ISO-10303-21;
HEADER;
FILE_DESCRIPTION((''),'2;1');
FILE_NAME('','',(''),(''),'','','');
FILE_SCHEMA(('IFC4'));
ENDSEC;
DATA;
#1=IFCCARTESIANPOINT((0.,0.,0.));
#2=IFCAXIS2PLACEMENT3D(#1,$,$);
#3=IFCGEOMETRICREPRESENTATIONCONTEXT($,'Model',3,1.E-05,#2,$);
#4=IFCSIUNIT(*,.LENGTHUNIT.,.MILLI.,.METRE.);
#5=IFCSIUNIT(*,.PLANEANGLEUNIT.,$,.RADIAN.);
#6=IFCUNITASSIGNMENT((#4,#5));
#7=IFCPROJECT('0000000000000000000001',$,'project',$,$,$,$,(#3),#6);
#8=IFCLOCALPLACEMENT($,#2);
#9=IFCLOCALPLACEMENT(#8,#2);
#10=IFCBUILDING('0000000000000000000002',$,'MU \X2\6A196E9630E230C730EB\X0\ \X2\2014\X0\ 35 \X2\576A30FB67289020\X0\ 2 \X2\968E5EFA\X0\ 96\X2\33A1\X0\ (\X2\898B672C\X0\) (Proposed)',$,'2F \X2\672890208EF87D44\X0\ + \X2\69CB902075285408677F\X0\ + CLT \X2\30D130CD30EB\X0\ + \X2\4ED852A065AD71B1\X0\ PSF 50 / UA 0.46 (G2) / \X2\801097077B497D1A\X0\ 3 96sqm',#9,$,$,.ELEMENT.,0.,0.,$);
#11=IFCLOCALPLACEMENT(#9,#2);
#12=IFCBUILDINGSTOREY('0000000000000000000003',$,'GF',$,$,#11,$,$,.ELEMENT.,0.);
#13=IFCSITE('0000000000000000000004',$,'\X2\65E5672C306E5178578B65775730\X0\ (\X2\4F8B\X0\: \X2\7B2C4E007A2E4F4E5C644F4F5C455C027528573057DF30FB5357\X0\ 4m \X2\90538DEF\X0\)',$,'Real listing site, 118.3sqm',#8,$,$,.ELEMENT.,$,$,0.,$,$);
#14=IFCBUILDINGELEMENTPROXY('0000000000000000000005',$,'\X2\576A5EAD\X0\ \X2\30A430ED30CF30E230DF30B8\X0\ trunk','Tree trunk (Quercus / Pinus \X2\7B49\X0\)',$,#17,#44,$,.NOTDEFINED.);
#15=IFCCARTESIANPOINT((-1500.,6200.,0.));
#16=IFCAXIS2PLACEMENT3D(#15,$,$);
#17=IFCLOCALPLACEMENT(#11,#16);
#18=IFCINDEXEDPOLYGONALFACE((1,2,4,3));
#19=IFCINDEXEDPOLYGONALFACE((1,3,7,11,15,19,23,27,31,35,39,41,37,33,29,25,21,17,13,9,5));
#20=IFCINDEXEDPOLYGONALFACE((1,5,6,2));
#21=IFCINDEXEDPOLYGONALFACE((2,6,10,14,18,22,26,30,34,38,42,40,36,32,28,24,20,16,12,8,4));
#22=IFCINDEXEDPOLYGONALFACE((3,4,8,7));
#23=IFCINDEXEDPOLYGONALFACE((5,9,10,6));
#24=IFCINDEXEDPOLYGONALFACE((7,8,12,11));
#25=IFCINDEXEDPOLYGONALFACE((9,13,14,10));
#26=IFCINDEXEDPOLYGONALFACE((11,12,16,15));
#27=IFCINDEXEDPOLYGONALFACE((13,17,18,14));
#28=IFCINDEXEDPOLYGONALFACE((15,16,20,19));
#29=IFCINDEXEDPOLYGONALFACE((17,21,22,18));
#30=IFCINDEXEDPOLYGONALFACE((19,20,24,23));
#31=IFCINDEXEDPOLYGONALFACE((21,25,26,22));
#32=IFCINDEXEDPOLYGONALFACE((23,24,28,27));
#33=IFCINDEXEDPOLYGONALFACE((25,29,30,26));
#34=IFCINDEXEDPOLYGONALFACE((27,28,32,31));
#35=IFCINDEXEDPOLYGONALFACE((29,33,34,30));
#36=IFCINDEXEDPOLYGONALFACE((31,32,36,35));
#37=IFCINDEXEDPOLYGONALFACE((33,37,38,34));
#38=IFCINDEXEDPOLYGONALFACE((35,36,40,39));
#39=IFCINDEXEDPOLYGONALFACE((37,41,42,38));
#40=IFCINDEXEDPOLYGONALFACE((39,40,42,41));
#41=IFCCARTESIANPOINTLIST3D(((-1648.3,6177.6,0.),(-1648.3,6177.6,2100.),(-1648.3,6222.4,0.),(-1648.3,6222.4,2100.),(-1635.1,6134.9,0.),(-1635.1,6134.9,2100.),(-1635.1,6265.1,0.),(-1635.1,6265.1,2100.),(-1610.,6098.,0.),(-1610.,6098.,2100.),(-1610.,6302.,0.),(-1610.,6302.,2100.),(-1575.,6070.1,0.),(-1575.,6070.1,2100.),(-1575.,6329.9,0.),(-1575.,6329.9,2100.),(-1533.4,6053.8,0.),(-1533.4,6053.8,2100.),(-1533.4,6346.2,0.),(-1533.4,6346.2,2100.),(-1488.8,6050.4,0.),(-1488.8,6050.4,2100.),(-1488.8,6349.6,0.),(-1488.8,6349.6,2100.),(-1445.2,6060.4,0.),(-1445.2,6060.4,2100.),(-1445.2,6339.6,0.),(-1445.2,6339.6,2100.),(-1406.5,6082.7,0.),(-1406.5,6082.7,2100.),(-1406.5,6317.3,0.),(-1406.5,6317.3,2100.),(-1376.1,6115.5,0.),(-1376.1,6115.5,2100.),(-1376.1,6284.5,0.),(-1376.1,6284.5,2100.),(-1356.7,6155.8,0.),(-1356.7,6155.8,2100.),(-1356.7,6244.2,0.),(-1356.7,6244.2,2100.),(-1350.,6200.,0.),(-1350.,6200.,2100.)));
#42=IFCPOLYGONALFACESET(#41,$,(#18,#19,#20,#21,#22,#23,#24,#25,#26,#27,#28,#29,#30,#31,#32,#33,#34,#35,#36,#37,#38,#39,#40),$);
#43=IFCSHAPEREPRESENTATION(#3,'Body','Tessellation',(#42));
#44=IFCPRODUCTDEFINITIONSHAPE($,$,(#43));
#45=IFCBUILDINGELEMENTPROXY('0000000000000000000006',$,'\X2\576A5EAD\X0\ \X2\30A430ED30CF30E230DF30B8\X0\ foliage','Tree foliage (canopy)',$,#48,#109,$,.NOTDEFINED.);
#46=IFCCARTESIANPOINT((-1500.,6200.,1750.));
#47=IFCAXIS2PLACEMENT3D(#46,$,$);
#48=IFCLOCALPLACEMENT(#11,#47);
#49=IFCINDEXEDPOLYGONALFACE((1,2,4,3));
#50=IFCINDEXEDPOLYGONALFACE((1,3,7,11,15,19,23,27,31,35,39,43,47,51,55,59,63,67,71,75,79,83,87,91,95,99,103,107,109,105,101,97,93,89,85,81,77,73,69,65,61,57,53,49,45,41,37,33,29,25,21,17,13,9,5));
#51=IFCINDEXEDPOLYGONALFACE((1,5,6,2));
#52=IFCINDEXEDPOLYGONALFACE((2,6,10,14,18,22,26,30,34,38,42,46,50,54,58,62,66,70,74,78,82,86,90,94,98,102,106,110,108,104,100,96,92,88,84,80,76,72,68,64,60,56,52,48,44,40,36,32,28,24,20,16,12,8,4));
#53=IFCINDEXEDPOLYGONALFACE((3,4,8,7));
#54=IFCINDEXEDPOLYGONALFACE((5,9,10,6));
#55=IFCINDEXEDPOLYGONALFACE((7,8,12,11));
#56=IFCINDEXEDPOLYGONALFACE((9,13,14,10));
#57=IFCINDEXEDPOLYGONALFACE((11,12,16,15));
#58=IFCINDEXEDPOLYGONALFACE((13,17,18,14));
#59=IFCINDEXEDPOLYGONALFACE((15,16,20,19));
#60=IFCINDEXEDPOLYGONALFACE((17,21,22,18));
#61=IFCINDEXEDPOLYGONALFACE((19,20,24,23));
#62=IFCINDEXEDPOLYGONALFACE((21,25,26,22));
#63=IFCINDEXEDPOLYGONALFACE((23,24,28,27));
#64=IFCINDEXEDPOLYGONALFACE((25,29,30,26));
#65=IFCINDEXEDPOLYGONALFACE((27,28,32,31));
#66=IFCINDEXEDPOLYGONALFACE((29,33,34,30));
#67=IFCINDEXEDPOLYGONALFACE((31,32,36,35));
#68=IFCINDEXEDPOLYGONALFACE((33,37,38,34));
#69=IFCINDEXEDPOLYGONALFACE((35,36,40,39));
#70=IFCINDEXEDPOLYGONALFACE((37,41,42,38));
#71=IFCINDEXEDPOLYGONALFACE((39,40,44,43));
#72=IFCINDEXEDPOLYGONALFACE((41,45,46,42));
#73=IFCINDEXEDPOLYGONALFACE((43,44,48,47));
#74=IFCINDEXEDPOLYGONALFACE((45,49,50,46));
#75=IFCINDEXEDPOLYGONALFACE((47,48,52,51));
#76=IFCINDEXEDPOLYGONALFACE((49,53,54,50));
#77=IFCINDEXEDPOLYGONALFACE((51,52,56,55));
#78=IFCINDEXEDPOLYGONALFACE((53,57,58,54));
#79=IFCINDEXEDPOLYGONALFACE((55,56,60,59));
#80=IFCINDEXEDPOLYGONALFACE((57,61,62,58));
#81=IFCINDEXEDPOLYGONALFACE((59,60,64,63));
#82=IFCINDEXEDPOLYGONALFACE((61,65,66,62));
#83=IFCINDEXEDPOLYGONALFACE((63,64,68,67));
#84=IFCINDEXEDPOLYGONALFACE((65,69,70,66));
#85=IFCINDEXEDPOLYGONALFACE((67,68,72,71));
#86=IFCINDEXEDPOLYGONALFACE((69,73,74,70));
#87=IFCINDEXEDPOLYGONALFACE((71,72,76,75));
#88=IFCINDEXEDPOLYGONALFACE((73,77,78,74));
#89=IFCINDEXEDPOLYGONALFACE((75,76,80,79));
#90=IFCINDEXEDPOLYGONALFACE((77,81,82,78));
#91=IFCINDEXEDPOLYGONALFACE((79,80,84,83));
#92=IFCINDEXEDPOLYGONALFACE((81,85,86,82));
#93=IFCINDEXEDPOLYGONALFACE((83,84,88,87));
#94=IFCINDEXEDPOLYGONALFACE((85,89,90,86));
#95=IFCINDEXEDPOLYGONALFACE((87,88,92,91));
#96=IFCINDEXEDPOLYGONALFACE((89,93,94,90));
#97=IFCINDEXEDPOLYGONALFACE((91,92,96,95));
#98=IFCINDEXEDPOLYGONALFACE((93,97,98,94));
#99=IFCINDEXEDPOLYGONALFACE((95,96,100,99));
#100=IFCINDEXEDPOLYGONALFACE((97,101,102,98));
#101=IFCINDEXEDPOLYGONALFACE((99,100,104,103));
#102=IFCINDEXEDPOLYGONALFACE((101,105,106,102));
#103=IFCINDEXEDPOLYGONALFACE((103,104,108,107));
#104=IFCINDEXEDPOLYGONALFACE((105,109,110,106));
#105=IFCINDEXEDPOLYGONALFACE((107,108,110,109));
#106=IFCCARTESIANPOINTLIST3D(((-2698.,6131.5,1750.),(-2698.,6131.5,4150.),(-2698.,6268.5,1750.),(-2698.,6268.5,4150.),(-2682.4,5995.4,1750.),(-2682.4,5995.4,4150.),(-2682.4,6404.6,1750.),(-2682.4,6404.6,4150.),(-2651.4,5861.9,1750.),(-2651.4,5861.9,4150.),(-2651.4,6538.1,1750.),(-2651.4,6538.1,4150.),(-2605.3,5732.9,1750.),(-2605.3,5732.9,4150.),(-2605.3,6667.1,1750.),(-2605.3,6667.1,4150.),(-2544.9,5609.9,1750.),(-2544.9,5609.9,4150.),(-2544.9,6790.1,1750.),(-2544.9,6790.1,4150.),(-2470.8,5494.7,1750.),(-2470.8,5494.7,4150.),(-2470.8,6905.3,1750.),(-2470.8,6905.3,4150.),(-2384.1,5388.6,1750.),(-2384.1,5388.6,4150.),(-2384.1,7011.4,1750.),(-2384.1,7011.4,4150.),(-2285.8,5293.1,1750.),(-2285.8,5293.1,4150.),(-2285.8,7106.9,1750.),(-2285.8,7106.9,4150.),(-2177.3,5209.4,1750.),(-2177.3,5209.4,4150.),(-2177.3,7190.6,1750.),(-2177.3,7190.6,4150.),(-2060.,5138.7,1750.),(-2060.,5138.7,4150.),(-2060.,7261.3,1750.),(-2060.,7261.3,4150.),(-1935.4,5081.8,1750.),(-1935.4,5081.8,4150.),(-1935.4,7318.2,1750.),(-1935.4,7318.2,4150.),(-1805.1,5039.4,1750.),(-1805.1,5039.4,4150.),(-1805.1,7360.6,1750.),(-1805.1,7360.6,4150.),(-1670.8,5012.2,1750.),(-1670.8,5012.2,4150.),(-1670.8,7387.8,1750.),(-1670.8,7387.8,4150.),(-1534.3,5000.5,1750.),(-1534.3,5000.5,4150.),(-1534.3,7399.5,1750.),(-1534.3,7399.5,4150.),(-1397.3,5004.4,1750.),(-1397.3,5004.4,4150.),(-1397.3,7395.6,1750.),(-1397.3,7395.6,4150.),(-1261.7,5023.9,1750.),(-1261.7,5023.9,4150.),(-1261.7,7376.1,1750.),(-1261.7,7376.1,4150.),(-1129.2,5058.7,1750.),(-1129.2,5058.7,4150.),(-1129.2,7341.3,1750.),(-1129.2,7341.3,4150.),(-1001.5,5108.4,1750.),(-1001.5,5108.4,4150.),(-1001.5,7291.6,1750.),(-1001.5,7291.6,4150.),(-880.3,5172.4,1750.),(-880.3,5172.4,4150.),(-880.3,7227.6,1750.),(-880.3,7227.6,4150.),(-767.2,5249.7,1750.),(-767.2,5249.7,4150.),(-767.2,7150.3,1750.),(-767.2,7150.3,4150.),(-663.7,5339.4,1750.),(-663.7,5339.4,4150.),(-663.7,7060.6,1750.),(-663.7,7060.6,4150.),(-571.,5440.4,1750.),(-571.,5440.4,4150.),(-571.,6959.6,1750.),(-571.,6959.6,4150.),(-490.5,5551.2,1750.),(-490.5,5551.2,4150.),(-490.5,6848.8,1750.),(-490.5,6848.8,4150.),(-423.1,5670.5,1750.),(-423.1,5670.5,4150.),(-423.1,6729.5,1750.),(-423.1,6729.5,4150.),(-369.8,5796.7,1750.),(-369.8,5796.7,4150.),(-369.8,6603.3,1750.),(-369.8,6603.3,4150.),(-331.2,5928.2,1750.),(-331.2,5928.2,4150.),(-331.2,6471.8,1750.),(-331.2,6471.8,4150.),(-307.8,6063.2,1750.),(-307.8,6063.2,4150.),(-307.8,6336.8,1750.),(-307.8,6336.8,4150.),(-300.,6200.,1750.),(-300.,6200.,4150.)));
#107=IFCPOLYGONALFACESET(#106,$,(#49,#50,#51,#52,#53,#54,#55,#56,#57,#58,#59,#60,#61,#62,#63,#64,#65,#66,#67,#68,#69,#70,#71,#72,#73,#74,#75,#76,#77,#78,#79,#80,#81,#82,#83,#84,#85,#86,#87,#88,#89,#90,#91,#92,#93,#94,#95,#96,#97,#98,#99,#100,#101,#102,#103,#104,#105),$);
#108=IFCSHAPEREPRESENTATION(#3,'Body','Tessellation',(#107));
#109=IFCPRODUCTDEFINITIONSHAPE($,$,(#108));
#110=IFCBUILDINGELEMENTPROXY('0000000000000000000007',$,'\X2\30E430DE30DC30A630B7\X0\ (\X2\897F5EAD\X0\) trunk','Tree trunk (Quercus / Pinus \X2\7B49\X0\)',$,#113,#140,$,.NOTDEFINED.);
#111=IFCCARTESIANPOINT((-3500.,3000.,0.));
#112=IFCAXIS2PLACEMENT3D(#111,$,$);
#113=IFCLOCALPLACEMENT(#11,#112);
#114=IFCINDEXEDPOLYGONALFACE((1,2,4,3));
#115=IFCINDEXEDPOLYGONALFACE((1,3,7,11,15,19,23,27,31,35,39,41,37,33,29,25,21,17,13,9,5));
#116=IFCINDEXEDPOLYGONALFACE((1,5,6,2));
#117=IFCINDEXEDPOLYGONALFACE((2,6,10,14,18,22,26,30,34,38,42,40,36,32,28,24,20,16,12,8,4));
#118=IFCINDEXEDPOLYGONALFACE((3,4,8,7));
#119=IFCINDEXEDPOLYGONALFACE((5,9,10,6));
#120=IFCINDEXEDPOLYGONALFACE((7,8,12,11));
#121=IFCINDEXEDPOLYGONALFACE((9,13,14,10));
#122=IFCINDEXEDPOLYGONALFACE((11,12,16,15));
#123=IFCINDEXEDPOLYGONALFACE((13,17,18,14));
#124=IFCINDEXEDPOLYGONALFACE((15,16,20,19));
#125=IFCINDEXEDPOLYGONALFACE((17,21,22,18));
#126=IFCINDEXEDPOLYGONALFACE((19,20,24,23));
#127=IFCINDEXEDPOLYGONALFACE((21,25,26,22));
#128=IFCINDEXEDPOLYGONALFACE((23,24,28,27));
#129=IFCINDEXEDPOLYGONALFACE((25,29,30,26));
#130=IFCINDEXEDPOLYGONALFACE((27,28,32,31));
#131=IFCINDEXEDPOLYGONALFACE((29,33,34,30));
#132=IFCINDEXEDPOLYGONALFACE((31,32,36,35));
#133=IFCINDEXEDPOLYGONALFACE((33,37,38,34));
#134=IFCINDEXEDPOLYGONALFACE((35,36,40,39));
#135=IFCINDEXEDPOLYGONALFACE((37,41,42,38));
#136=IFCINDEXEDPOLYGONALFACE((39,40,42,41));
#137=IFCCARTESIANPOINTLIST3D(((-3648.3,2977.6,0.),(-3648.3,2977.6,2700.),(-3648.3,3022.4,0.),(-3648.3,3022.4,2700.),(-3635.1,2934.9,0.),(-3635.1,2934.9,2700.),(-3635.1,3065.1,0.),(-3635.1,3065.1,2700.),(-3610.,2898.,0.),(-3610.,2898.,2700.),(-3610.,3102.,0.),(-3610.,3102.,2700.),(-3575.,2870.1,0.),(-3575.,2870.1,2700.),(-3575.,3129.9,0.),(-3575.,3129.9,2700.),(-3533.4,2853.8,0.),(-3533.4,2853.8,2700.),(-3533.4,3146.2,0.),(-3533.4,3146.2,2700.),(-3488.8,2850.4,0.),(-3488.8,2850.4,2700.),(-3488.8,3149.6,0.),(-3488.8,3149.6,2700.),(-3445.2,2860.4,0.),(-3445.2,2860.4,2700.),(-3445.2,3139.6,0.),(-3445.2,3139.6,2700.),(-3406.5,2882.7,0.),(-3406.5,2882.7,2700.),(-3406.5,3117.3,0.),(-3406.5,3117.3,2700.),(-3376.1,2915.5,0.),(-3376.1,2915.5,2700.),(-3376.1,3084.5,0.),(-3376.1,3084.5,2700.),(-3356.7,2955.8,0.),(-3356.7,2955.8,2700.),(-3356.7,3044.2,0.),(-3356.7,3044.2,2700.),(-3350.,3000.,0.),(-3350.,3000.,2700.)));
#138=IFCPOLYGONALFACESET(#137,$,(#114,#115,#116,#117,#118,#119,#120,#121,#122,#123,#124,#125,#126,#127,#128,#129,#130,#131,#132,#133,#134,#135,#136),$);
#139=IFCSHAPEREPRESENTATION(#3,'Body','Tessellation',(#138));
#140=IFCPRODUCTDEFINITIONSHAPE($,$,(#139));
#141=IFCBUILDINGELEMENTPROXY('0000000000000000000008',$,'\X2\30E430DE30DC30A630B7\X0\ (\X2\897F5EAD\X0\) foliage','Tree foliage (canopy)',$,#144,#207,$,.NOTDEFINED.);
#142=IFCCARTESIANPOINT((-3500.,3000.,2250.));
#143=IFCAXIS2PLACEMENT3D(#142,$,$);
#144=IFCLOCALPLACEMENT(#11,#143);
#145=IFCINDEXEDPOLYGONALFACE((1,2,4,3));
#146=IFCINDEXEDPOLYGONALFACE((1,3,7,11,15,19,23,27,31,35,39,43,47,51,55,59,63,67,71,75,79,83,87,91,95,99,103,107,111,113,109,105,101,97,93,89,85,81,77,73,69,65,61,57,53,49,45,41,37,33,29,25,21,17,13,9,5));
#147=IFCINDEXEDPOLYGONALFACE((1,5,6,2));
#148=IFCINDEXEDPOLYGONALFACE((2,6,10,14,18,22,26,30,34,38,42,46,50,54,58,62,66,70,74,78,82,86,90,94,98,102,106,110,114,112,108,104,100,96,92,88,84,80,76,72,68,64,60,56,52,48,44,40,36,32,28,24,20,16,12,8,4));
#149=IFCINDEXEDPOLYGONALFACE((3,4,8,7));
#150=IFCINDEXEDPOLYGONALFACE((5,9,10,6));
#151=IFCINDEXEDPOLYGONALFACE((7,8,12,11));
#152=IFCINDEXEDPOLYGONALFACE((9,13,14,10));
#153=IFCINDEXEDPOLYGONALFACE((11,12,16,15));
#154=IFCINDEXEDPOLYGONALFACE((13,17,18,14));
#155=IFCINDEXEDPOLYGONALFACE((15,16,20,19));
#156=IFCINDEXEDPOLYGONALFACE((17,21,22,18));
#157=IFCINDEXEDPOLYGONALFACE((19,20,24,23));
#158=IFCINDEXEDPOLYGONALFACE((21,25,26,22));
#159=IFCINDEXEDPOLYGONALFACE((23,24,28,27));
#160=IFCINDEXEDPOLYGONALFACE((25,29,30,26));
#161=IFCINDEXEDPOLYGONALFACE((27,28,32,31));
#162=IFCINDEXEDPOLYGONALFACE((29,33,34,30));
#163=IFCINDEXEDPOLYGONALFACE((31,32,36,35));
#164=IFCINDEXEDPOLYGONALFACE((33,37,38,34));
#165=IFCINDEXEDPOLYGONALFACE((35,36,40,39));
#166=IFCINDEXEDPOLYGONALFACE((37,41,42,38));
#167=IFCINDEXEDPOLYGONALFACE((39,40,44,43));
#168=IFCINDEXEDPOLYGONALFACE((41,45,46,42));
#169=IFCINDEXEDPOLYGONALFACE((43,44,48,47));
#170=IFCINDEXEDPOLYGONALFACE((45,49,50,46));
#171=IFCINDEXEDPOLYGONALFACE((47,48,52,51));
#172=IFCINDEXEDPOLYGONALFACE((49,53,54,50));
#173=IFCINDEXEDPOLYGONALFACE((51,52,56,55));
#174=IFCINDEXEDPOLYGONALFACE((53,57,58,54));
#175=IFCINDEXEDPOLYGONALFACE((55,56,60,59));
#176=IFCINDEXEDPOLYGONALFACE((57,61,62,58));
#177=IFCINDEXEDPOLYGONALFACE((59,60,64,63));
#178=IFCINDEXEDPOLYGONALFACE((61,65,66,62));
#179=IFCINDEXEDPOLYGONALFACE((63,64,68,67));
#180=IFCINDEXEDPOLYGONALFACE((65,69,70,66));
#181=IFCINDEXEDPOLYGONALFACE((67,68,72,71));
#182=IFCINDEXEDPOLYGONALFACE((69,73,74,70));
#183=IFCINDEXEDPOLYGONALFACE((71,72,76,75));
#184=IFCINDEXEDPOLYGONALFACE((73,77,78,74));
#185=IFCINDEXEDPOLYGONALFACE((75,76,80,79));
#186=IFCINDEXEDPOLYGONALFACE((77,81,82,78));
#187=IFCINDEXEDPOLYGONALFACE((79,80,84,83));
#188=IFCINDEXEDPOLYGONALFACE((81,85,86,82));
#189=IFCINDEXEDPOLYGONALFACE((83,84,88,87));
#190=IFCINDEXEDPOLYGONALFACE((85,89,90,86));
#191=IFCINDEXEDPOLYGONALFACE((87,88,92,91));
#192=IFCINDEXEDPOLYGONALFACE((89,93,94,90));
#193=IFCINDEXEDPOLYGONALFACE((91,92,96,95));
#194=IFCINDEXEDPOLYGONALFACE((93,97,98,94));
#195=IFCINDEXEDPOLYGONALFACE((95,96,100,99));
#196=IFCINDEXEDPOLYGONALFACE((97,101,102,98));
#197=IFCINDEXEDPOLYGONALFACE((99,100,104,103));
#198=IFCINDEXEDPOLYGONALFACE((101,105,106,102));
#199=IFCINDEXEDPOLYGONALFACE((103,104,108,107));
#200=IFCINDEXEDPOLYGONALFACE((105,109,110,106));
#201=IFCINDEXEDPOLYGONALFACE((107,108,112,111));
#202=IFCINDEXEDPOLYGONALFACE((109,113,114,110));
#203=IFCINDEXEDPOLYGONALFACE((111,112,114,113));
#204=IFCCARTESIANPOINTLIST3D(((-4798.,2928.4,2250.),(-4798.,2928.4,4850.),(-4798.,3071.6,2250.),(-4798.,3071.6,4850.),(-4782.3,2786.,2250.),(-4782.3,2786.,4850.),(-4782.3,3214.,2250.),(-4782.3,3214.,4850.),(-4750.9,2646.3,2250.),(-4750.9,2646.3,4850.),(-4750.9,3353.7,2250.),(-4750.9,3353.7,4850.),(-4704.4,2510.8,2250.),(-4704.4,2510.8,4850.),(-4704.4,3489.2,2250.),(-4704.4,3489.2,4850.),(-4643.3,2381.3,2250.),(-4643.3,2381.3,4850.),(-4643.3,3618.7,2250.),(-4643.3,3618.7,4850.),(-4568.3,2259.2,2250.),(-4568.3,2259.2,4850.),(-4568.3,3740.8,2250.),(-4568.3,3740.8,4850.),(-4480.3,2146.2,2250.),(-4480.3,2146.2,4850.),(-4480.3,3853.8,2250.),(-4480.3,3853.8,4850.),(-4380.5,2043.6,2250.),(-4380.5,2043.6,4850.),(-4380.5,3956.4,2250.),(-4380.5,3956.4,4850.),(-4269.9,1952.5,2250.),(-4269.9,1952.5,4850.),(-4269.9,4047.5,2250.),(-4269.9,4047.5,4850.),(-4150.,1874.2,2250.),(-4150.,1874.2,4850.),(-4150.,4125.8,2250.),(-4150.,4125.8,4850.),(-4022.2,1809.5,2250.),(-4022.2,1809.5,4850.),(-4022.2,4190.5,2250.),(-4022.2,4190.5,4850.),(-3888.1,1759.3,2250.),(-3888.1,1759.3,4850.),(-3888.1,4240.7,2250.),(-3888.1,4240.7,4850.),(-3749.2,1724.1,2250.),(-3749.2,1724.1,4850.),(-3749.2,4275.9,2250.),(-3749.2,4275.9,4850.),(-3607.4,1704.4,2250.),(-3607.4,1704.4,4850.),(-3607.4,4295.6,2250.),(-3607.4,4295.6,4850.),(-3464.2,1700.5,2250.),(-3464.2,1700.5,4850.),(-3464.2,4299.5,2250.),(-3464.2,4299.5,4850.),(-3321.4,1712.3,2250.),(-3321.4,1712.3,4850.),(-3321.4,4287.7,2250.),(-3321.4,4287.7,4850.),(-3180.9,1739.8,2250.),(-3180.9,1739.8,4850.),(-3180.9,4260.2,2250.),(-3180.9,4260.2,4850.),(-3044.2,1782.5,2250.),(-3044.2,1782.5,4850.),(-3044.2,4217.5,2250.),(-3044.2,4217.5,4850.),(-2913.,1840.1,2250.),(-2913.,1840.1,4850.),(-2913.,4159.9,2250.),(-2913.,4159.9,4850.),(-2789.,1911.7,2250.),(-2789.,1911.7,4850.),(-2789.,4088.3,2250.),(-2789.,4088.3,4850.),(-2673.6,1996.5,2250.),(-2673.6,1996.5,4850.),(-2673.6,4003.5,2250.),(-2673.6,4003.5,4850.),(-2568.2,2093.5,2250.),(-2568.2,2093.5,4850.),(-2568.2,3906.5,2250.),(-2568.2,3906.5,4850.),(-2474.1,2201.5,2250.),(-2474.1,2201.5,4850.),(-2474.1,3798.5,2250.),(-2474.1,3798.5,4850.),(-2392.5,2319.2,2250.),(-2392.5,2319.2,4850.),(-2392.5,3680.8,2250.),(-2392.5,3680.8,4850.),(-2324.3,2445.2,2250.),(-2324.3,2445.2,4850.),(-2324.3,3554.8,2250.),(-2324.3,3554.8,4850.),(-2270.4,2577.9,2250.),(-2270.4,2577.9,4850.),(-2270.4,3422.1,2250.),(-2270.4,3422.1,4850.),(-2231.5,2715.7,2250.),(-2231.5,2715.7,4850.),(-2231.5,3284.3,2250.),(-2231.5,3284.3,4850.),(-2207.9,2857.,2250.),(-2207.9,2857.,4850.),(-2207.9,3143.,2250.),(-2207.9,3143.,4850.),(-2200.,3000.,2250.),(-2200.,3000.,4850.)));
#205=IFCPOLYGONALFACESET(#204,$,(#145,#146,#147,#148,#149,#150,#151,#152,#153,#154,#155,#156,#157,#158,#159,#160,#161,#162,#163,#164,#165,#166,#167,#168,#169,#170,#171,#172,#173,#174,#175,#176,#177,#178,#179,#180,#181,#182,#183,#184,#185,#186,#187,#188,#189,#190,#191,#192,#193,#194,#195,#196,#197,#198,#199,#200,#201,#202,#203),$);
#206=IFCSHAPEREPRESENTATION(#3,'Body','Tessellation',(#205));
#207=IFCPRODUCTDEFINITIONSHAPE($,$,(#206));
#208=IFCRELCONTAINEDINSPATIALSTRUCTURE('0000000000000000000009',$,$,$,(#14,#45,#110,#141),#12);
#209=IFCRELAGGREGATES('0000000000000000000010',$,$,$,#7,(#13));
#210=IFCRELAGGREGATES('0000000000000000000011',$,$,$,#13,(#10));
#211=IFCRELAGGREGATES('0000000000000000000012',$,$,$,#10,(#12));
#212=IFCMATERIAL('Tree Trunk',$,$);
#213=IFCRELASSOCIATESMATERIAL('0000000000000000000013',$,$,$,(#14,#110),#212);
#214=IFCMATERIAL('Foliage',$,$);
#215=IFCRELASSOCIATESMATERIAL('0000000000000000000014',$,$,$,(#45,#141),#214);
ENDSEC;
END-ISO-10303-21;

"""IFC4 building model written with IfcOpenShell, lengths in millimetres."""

from ifc_helpers import new_model, si_unit, frame, origin, origin_2d, place, context, project, spatial, circle, extrude, material, element, save


model = new_model("IFC4")

# Units and contexts
model_context = context("Model", 3, precision=1e-05, world=origin())
ifc_project = project(units=[si_unit("LENGTHUNIT", "METRE", prefix="MILLI"), si_unit("PLANEANGLEUNIT", "RADIAN")], contexts=[model_context])

# Site, building, storey
site_placement = place(None, origin())
site = spatial("IfcSite", under=ifc_project, at=site_placement, Name="日本の典型敷地 (例: 第一種低層住居専用地域・南 4m 道路)", ObjectType="Real listing site, 118.3sqm", CompositionType="ELEMENT", RefElevation=0.0)
building_placement = place(site_placement, origin())
building = spatial("IfcBuilding", under=site, at=building_placement, Name="MU 標準モデル — 35 坪・木造 2 階建 96㎡ (見本) (Proposed)", ObjectType="2F 木造軸組 + 構造用合板 + CLT パネル + 付加断熱 PSF 50 / UA 0.46 (G2) / 耐震等級 3 96sqm", CompositionType="ELEMENT", ElevationOfRefHeight=0.0, ElevationOfTerrain=0.0)
storey_placement = place(building_placement, origin())
storey = spatial("IfcBuildingStorey", under=building, at=storey_placement, Name="GF", CompositionType="ELEMENT", Elevation=0.0)

# Building element proxies
ifc_material_1 = material(Name="Tree Trunk")
proxy_1_placement = place(storey_placement, frame((-1500.0, 6200.0, 0.0)))
element("IfcBuildingElementProxy", 1, at=proxy_1_placement, inside=storey, material=ifc_material_1, Name="坪庭 イロハモミジ trunk", Description="Tree trunk (Quercus / Pinus 等)", PredefinedType="NOTDEFINED", context=model_context, shape_type="SweptSolid", body=[
    extrude(circle(Radius=150.0, at=origin_2d()), frame((-1500.0, 6200.0, 0.0)), (0.0, 0.0, 1.0), 2100.0),
])
ifc_material_2 = material(Name="Foliage")
proxy_2_placement = place(storey_placement, frame((-1500.0, 6200.0, 1750.0)))
element("IfcBuildingElementProxy", 2, at=proxy_2_placement, inside=storey, material=ifc_material_2, Name="坪庭 イロハモミジ foliage", Description="Tree foliage (canopy)", PredefinedType="NOTDEFINED", context=model_context, shape_type="SweptSolid", body=[
    extrude(circle(Radius=1200.0, at=origin_2d()), frame((-1500.0, 6200.0, 1750.0)), (0.0, 0.0, 1.0), 2400.0),
])
proxy_3_placement = place(storey_placement, frame((-3500.0, 3000.0, 0.0)))
element("IfcBuildingElementProxy", 3, at=proxy_3_placement, inside=storey, material=ifc_material_1, Name="ヤマボウシ (西庭) trunk", Description="Tree trunk (Quercus / Pinus 等)", PredefinedType="NOTDEFINED", context=model_context, shape_type="SweptSolid", body=[
    extrude(circle(Radius=150.0, at=origin_2d()), frame((-3500.0, 3000.0, 0.0)), (0.0, 0.0, 1.0), 2700.0),
])
proxy_4_placement = place(storey_placement, frame((-3500.0, 3000.0, 2250.0)))
element("IfcBuildingElementProxy", 4, at=proxy_4_placement, inside=storey, material=ifc_material_2, Name="ヤマボウシ (西庭) foliage", Description="Tree foliage (canopy)", PredefinedType="NOTDEFINED", context=model_context, shape_type="SweptSolid", body=[
    extrude(circle(Radius=1300.0, at=origin_2d()), frame((-3500.0, 3000.0, 2250.0)), (0.0, 0.0, 1.0), 2600.0),
])

save(model, "model.ifc")
